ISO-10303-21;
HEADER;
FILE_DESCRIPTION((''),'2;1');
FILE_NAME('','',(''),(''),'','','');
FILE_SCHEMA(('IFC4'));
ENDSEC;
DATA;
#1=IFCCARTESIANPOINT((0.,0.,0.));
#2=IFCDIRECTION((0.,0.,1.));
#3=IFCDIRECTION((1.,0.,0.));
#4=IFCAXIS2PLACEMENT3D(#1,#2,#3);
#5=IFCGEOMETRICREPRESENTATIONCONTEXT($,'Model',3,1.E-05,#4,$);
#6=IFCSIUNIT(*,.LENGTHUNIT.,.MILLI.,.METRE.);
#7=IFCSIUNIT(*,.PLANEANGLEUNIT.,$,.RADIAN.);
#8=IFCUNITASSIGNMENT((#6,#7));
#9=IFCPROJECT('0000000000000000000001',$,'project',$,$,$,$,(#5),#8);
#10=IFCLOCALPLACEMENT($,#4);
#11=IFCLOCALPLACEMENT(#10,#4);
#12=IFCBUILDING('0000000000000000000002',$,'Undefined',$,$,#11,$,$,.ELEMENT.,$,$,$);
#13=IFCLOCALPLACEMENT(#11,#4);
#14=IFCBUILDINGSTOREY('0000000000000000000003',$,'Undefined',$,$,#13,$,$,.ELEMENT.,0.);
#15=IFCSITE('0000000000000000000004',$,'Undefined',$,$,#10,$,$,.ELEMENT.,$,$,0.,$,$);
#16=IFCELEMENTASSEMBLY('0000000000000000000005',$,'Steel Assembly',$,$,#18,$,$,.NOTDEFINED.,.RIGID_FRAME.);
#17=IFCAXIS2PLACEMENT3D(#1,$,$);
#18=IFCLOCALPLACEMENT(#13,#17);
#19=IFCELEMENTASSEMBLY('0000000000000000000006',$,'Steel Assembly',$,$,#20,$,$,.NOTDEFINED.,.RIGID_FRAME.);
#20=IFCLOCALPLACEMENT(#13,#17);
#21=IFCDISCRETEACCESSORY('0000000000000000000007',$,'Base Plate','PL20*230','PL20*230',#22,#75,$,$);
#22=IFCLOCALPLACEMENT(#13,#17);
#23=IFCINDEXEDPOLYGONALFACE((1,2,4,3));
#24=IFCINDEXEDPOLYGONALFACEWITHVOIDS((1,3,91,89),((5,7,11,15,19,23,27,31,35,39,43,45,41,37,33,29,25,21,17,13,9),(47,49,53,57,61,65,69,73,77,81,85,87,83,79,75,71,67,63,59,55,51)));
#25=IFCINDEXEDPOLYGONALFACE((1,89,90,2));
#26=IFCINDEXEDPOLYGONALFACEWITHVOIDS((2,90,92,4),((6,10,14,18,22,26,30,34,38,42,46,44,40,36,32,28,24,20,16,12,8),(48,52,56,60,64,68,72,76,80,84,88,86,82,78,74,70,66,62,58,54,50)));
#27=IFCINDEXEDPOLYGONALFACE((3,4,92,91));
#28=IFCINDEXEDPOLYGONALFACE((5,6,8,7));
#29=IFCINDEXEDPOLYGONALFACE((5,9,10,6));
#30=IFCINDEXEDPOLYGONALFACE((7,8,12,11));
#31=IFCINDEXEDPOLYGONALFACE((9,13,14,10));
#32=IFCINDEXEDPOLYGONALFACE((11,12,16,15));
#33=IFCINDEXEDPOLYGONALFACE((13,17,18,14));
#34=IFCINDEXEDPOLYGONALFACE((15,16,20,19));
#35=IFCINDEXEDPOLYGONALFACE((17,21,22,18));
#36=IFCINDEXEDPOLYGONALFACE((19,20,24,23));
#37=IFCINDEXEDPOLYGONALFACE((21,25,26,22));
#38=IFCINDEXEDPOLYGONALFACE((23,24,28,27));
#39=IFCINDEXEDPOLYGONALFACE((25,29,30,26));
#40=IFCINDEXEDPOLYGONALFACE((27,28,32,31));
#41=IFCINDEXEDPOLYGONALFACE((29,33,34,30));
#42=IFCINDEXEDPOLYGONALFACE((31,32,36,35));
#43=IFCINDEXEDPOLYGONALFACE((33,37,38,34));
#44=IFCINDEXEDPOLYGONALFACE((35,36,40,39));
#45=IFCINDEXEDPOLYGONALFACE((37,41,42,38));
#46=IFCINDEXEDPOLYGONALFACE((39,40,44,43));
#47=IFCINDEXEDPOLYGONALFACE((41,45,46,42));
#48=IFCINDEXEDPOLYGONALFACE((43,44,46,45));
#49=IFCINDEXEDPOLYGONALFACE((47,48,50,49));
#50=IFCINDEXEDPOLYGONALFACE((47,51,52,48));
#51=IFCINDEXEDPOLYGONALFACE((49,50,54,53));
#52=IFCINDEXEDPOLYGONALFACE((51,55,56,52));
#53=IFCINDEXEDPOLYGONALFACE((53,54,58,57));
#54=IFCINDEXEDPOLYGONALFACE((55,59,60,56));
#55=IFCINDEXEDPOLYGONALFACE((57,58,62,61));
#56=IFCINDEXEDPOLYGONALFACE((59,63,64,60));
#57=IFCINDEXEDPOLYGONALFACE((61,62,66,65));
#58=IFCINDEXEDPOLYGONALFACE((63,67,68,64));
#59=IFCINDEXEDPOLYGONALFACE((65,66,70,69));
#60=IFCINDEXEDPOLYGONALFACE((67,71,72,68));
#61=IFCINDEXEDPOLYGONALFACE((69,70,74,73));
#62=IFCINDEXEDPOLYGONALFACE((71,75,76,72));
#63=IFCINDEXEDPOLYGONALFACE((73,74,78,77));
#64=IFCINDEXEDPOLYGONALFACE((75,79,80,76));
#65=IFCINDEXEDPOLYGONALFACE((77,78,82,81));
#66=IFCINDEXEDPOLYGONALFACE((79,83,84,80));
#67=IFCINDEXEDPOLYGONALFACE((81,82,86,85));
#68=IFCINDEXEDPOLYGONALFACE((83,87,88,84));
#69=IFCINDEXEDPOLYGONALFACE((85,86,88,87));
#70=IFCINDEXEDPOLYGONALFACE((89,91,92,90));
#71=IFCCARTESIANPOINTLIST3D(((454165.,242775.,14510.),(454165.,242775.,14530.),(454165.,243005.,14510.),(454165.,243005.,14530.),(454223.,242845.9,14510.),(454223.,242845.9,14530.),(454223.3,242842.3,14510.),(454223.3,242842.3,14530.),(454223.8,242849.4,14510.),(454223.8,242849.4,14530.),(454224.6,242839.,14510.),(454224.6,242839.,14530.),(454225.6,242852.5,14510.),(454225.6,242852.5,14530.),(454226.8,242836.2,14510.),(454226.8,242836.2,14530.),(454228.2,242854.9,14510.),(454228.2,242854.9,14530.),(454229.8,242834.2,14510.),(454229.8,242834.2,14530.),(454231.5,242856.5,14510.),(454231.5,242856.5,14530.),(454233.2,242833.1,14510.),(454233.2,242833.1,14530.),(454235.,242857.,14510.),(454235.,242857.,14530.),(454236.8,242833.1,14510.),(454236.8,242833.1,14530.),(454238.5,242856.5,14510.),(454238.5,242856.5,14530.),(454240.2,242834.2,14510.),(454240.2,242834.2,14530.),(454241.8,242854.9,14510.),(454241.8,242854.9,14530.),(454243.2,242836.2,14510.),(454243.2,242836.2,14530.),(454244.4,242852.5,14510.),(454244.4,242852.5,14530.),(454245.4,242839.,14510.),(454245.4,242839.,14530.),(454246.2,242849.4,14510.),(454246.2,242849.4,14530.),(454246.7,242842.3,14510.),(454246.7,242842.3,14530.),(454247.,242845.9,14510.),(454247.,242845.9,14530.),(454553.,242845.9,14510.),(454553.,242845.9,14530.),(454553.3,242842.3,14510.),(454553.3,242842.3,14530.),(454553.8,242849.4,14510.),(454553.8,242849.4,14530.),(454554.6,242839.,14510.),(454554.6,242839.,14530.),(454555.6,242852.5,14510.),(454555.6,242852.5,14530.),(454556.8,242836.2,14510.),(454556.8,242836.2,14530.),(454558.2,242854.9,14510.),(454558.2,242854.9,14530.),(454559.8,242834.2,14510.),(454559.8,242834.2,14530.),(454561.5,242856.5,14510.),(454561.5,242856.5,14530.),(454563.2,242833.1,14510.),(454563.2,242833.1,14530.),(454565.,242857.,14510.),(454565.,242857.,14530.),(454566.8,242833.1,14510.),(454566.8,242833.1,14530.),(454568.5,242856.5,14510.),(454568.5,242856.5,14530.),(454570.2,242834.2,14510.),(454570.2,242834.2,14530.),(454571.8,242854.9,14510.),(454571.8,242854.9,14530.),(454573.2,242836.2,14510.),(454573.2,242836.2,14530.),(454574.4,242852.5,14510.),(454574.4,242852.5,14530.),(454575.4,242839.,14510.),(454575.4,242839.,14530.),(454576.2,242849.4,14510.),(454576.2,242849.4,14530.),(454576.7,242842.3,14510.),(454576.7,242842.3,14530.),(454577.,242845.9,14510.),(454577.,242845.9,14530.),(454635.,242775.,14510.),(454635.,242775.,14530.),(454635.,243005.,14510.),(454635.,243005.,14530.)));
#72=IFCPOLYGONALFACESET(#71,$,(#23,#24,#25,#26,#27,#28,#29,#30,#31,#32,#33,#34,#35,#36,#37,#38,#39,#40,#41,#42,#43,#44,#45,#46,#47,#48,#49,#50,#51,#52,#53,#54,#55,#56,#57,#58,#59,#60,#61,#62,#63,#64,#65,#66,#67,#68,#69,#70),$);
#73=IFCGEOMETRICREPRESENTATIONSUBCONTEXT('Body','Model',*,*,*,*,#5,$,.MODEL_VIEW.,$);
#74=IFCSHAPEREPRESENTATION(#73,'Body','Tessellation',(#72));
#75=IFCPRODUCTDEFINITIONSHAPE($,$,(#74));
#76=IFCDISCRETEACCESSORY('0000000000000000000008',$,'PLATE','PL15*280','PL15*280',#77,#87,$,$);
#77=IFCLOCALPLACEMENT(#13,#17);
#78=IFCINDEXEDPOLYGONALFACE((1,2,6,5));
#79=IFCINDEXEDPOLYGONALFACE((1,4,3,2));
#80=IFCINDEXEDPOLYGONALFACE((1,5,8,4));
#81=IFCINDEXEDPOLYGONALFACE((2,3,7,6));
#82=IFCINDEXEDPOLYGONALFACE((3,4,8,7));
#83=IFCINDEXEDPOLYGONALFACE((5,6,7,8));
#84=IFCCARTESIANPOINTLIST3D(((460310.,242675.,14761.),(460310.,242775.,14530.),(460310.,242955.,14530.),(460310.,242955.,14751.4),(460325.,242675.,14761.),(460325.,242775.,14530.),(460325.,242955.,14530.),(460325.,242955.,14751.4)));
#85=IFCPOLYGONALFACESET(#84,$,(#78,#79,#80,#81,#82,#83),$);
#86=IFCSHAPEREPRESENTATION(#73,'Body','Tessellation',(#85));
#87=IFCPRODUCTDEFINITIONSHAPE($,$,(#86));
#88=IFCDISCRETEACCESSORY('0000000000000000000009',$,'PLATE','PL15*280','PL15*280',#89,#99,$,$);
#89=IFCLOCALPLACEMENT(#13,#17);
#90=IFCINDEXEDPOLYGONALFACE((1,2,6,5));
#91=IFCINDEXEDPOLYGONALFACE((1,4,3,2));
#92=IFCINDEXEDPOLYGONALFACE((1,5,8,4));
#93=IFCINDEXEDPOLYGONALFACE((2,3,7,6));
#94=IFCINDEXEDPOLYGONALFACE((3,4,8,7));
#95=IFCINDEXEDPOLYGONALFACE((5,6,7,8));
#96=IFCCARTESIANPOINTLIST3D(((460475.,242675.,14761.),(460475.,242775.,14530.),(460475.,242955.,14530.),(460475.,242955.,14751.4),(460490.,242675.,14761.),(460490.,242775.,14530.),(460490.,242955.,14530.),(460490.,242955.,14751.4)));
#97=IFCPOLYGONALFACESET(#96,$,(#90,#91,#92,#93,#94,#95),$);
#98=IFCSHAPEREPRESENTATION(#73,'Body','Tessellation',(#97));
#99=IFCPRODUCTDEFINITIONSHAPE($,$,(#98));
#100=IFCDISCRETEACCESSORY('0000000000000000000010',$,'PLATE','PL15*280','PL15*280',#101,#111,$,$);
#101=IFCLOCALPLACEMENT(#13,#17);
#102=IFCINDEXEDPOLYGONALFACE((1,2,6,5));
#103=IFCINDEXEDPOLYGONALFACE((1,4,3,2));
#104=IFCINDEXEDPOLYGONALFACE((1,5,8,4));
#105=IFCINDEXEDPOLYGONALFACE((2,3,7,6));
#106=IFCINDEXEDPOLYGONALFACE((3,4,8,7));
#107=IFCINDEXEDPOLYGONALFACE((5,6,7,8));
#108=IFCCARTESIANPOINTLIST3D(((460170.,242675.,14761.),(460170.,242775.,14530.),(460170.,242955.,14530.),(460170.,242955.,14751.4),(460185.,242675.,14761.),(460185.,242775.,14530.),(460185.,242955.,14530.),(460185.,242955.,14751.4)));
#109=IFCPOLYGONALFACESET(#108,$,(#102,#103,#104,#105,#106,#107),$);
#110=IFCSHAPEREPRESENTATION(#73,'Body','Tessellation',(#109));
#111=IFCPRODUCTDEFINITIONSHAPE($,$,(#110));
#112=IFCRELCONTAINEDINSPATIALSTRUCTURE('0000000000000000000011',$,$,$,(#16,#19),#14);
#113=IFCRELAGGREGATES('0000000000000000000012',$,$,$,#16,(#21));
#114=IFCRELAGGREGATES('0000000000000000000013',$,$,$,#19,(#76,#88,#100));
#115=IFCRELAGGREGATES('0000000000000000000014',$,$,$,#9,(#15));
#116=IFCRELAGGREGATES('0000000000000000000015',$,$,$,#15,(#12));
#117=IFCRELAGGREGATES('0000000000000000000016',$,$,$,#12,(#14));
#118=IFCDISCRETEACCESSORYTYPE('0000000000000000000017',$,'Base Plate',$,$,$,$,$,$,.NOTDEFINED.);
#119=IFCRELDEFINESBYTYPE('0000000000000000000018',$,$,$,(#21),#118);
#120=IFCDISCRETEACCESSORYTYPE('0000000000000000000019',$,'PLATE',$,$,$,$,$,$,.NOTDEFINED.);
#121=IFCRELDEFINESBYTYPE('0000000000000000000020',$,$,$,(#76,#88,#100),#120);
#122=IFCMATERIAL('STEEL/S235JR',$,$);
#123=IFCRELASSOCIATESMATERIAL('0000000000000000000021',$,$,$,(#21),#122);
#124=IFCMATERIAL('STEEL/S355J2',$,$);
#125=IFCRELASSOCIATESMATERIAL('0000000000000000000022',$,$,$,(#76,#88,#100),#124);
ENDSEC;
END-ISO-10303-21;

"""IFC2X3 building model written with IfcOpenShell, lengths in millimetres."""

from ifc_helpers import new_model, si_unit, frame, origin_with_axes, origin_2d_with_axis, place, context, subcontext, project, spatial, polyline, circle, outline, extrude, boolean, material, type_object, element, aggregate, save


model = new_model("IFC2X3")

# Units and contexts
model_context = context("Model", 3, precision=1e-05, world=origin_with_axes())
body_context = subcontext(model_context, "Body", "Model", "MODEL_VIEW")
ifc_project = project(units=[si_unit("LENGTHUNIT", "METRE", prefix="MILLI"), si_unit("PLANEANGLEUNIT", "RADIAN")], contexts=[model_context])

# Site, building, storey
site_placement = place(None, origin_with_axes())
site = spatial("IfcSite", under=ifc_project, at=site_placement, Name="Undefined", CompositionType="ELEMENT", RefElevation=0.0)
building_placement = place(site_placement, origin_with_axes())
building = spatial("IfcBuilding", under=site, at=building_placement, Name="Undefined", CompositionType="ELEMENT")
storey_placement = place(building_placement, origin_with_axes())
storey = spatial("IfcBuildingStorey", under=building, at=storey_placement, Name="Undefined", CompositionType="ELEMENT", Elevation=0.0)

# Shared definitions
ifc_material_1 = material(Name="STEEL/S235JR")

# Element assembly
assembly_1_placement = place(storey_placement, origin_with_axes())
assembly_1 = element("IfcElementAssembly", 1, at=assembly_1_placement, inside=storey, Name="Steel Assembly", AssemblyPlace="NOTDEFINED", PredefinedType="RIGID_FRAME")

# Element assembly
assembly_2_placement = place(storey_placement, origin_with_axes())
assembly_2 = element("IfcElementAssembly", 2, at=assembly_2_placement, inside=storey, Name="Steel Assembly", AssemblyPlace="NOTDEFINED", PredefinedType="RIGID_FRAME")

# Discrete accessories
discrete_accessory_type_1 = type_object("IfcDiscreteAccessoryType", Name="Base Plate")
discrete_accessory_1_placement = place(assembly_1_placement, frame((454165.0, 243005.0, 14520.0), z_axis=(0.0, 0.0, -1.0), x_axis=(1.0, 0.0, 0.0)))
discrete_accessory_1 = element("IfcDiscreteAccessory", 3, at=discrete_accessory_1_placement, type_object=discrete_accessory_type_1, material=ifc_material_1, Name="Base Plate", Description="PL20*230", ObjectType="PL20*230", context=body_context, shape_type="CSG", body=[
    boolean("DIFFERENCE", boolean("DIFFERENCE", extrude(outline(polyline([(0.0, 0.0), (470.0, 0.0), (470.0, 230.0), (0.0, 230.0), (0.0, 0.0)])), frame((0.0, 0.0, -10.0), z_axis=(0.0, 0.0, 1.0), x_axis=(1.0, 0.0, 0.0)), (0.0, 0.0, 1.0), 20.0), extrude(circle(Radius=12.0, at=origin_2d_with_axis()), frame((70.0, 160.0, -80.0), z_axis=(0.0, 0.0, 1.0), x_axis=(0.0, -1.0, 0.0)), (0.0, 0.0, 1.0), 170.0)), extrude(circle(Radius=12.0, at=origin_2d_with_axis()), frame((400.0, 160.0, -80.0), z_axis=(0.0, 0.0, 1.0), x_axis=(0.0, -1.0, 0.0)), (0.0, 0.0, 1.0), 170.0)),
])
aggregate(assembly_1, [discrete_accessory_1])
ifc_material_2 = material(Name="STEEL/S355J2")
discrete_accessory_type_2 = type_object("IfcDiscreteAccessoryType", Name="PLATE")
discrete_accessory_2_placement = place(assembly_2_placement, frame((460317.5, 242955.0, 14530.0), z_axis=(-1.0, 0.0, 0.0), x_axis=(0.0, -1.0, 0.0)))
discrete_accessory_2 = element("IfcDiscreteAccessory", 4, at=discrete_accessory_2_placement, type_object=discrete_accessory_type_2, material=ifc_material_2, Name="PLATE", Description="PL15*280", ObjectType="PL15*280", context=body_context, shape_type="SweptSolid", body=[
    extrude(outline(polyline([(0.0, 0.0), (180.0, 0.0), (280.0, 231.0), (0.0, 221.4), (0.0, 0.0)])), frame((0.0, 0.0, -7.5), z_axis=(0.0, 0.0, 1.0), x_axis=(1.0, 0.0, 0.0)), (0.0, 0.0, 1.0), 15.0),
])
discrete_accessory_3_placement = place(assembly_2_placement, frame((460482.5, 242955.0, 14530.0), z_axis=(-1.0, 0.0, 0.0), x_axis=(0.0, -1.0, 0.0)))
discrete_accessory_3 = element("IfcDiscreteAccessory", 5, at=discrete_accessory_3_placement, type_object=discrete_accessory_type_2, material=ifc_material_2, Name="PLATE", Description="PL15*280", ObjectType="PL15*280", context=body_context, shape_type="SweptSolid", body=[
    extrude(outline(polyline([(0.0, 0.0), (180.0, 0.0), (280.0, 231.0), (0.0, 221.4), (0.0, 0.0)])), frame((0.0, 0.0, -7.5), z_axis=(0.0, 0.0, 1.0), x_axis=(1.0, 0.0, 0.0)), (0.0, 0.0, 1.0), 15.0),
])
discrete_accessory_4_placement = place(assembly_2_placement, frame((460177.5, 242955.0, 14530.0), z_axis=(-1.0, 0.0, 0.0), x_axis=(0.0, -1.0, 0.0)))
discrete_accessory_4 = element("IfcDiscreteAccessory", 6, at=discrete_accessory_4_placement, type_object=discrete_accessory_type_2, material=ifc_material_2, Name="PLATE", Description="PL15*280", ObjectType="PL15*280", context=body_context, shape_type="SweptSolid", body=[
    extrude(outline(polyline([(0.0, 0.0), (180.0, 0.0), (280.0, 231.0), (0.0, 221.4), (0.0, 0.0)])), frame((0.0, 0.0, -7.5), z_axis=(0.0, 0.0, 1.0), x_axis=(1.0, 0.0, 0.0)), (0.0, 0.0, 1.0), 15.0),
])
aggregate(assembly_2, [discrete_accessory_2, discrete_accessory_3, discrete_accessory_4])

save(model, "model.ifc")
